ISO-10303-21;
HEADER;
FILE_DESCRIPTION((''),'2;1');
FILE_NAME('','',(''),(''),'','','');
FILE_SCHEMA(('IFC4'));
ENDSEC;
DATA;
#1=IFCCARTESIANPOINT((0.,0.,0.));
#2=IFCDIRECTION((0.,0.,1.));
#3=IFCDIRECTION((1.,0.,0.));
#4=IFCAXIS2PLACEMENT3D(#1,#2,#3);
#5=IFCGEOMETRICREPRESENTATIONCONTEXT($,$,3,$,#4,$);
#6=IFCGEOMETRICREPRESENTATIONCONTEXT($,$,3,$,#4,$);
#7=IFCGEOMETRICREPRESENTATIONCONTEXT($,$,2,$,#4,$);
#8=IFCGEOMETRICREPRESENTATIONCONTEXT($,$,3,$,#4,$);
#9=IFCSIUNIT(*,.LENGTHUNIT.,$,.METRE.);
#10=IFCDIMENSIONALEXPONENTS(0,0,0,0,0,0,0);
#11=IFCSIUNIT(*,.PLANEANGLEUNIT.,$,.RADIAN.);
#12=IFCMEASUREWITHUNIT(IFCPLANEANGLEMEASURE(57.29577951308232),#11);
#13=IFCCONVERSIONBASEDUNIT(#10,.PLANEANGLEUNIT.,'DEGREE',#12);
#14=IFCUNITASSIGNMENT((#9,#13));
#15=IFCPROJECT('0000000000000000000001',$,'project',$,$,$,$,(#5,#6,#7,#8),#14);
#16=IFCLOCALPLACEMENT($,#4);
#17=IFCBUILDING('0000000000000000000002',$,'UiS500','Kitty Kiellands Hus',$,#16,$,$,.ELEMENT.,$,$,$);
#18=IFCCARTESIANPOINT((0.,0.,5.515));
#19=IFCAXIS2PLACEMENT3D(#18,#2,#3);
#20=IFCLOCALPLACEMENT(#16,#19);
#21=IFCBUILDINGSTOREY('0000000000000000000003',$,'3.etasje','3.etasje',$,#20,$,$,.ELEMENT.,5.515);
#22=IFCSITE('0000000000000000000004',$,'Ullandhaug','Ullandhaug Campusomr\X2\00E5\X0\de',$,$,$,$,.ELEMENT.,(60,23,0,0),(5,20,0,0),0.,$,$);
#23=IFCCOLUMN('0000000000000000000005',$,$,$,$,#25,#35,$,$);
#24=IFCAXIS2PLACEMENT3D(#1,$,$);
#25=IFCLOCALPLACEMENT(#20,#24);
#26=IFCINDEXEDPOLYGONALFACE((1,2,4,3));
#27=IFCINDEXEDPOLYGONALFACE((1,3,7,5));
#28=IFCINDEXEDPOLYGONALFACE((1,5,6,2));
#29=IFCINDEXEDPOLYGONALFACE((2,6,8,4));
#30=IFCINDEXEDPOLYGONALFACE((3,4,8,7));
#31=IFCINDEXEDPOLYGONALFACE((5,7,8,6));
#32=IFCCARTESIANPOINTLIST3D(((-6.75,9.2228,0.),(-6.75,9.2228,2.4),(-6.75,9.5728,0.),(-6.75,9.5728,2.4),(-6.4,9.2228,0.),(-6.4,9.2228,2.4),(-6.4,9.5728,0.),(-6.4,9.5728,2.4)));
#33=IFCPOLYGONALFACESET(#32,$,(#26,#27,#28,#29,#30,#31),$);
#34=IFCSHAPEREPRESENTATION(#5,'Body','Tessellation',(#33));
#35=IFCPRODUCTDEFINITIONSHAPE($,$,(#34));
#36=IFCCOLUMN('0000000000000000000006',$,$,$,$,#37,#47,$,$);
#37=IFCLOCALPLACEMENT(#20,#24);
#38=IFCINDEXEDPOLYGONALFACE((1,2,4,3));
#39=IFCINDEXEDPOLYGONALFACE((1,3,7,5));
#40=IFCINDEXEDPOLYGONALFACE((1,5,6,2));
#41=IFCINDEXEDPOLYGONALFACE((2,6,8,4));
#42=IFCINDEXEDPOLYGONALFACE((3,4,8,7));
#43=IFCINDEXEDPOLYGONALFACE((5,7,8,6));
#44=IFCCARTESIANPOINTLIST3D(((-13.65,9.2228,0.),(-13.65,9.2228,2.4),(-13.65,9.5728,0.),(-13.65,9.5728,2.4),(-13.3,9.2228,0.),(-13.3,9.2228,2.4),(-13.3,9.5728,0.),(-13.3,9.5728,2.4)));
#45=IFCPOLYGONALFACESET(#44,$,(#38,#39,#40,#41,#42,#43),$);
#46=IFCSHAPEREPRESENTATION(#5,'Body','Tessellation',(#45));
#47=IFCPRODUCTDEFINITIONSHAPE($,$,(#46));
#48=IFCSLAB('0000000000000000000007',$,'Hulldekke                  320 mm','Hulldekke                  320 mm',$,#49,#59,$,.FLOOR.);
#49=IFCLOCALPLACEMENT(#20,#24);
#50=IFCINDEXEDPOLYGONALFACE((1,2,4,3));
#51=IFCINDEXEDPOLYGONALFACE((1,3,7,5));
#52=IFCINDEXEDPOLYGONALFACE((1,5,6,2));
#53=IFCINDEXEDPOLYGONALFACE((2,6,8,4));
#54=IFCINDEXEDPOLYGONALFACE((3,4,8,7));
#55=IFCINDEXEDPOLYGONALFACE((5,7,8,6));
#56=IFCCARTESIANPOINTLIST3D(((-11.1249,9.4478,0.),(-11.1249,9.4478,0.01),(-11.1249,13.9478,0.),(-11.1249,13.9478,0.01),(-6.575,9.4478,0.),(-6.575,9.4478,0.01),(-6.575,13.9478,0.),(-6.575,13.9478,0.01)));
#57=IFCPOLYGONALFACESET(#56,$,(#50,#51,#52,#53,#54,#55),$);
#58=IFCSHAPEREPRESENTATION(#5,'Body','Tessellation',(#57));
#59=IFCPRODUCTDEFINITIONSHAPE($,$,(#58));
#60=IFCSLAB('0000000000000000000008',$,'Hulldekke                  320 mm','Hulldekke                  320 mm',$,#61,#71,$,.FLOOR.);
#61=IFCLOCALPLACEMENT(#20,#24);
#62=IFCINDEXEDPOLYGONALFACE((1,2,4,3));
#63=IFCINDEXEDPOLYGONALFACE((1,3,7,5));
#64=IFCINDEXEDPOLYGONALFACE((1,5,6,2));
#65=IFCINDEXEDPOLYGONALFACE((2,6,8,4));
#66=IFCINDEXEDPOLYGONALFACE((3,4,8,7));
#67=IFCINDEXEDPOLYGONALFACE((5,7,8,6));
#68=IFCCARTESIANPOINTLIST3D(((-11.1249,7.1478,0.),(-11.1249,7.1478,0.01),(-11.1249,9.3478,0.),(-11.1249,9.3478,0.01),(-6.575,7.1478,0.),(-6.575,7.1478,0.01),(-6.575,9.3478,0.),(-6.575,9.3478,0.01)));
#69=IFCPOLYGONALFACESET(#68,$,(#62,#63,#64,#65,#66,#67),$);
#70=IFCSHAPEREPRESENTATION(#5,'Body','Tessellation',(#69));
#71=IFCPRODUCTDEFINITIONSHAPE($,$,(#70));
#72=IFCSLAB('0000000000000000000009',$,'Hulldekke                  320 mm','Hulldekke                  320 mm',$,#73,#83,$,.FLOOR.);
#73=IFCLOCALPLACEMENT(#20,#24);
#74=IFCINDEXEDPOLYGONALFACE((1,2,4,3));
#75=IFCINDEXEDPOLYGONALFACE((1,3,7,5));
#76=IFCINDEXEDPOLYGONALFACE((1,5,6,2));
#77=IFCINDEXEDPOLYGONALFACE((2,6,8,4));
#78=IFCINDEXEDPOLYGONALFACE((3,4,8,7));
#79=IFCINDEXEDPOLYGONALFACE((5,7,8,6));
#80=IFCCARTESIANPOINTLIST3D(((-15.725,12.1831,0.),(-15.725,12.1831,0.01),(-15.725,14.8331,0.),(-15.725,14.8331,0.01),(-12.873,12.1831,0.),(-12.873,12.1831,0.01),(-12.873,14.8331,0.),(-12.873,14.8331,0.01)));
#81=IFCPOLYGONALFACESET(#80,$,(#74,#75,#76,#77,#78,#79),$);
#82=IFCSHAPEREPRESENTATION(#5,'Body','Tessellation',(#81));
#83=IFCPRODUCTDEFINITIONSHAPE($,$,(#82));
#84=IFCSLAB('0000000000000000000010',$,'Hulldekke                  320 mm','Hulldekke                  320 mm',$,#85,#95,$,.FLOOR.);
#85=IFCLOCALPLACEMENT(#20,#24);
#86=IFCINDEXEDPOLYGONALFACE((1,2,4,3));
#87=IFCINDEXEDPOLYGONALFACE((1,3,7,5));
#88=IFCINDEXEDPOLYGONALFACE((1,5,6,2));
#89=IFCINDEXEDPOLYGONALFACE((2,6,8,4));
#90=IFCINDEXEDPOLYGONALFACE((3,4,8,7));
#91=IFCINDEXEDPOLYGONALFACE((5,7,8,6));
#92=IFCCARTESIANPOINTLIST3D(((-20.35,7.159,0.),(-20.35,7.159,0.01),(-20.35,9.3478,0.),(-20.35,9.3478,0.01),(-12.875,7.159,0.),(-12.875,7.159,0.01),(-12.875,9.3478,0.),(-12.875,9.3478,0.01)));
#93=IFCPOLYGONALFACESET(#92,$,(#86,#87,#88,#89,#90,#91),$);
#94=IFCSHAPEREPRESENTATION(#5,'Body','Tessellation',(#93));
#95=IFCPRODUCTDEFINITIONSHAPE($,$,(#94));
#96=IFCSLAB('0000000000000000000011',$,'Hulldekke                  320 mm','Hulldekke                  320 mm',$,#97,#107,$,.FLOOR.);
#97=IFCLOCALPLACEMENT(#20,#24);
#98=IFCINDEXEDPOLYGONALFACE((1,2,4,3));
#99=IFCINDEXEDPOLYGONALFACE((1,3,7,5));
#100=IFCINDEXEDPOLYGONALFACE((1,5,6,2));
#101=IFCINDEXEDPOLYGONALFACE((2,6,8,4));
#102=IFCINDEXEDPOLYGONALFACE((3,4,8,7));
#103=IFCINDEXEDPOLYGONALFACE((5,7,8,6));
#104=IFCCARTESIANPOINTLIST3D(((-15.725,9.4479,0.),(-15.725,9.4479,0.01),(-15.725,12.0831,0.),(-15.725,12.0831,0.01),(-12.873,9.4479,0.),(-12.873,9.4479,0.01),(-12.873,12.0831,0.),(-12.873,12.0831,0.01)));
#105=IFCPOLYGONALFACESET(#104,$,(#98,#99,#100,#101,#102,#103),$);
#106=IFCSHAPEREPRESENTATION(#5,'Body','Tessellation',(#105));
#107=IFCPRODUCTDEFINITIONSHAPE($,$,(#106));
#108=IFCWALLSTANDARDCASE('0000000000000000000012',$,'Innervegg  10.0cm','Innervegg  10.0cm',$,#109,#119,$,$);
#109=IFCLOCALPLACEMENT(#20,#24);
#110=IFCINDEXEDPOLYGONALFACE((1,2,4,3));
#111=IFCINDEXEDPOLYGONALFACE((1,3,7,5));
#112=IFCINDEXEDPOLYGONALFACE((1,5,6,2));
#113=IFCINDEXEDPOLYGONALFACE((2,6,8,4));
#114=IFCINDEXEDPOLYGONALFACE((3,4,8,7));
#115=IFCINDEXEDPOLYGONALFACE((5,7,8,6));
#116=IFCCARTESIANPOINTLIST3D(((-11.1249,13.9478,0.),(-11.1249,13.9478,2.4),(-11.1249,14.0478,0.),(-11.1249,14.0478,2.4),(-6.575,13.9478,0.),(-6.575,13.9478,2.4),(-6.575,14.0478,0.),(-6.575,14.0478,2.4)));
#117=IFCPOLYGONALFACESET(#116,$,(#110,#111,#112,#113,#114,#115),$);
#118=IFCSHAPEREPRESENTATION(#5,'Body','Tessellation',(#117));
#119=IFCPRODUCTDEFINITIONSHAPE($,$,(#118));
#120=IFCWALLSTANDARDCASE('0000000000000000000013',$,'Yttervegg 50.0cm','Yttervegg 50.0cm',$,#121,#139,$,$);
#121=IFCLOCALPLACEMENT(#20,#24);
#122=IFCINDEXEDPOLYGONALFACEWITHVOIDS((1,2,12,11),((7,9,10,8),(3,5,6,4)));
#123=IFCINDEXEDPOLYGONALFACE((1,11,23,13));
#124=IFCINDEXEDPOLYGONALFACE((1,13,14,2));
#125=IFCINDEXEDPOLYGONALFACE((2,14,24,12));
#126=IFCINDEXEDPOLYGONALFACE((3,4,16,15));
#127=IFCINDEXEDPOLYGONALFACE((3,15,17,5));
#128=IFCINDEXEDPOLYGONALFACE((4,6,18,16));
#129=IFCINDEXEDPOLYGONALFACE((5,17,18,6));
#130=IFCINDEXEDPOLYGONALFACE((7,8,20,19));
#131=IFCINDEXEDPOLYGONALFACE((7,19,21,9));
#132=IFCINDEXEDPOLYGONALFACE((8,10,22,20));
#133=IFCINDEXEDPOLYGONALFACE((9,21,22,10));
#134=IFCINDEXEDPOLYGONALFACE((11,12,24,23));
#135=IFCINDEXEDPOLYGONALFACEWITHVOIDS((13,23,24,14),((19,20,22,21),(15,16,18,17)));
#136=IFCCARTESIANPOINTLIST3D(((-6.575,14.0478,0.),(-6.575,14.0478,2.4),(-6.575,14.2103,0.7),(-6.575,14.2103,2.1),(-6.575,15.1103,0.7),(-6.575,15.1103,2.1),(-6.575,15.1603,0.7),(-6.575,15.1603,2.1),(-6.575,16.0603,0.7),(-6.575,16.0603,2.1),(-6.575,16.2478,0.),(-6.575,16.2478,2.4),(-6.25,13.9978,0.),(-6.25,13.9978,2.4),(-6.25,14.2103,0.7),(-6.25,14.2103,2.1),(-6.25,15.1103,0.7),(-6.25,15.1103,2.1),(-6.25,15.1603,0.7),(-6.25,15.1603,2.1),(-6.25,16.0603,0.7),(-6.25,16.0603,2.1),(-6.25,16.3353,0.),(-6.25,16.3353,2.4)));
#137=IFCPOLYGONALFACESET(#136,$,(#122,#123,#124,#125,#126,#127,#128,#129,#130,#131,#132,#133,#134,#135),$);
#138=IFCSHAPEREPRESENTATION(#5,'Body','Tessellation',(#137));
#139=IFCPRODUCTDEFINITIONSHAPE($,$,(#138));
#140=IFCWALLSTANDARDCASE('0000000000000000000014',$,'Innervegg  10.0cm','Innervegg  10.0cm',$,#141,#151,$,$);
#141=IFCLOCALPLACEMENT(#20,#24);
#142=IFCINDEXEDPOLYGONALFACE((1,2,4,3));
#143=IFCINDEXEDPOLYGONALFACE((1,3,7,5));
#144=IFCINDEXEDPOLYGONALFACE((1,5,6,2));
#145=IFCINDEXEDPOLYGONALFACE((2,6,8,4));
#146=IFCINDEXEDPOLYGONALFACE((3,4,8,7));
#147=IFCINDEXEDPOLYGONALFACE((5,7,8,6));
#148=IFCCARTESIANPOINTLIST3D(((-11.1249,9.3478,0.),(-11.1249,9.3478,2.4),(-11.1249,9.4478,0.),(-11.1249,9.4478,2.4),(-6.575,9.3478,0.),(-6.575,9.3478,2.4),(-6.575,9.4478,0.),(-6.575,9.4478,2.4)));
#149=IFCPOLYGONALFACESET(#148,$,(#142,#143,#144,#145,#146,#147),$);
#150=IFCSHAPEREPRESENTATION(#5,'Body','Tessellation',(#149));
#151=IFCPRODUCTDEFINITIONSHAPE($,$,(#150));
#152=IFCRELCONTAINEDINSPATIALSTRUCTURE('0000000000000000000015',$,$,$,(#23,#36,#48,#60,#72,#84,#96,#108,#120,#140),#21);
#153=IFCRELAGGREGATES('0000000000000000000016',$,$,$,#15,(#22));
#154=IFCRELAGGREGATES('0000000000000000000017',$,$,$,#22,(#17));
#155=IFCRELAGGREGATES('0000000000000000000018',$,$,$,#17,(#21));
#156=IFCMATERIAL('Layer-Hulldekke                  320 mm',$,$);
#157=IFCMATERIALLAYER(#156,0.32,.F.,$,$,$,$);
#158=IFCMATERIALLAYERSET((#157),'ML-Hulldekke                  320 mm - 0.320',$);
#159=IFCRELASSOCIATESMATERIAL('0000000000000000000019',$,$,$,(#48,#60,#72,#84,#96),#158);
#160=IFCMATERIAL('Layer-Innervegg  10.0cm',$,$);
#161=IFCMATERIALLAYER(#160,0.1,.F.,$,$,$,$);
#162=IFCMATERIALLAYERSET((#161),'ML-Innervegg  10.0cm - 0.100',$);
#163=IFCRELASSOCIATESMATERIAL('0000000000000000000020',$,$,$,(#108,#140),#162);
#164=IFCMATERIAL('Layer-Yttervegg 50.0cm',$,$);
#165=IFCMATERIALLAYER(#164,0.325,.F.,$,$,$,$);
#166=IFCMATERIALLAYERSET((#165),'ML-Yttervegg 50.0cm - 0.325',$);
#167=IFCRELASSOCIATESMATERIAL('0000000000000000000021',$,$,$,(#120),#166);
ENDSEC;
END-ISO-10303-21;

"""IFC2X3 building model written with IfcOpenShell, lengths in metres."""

from ifc_helpers import new_model, entity, si_unit, converted_unit, frame, origin_with_axes, origin_2d_with_axis, place, context, project, spatial, polyline, rectangle, outline, extrude, material, layer, layer_set, layer_usage, element, save


model = new_model("IFC2X3")

# Units and contexts
context_of_model_1 = context(None, 3, world=origin_with_axes())
context_of_model_2 = context(None, 3, world=origin_with_axes())
context_of_model_3 = context(None, 2, world=origin_with_axes())
context_of_model_4 = context(None, 3, world=origin_with_axes())
ifc_project = project(units=[si_unit("LENGTHUNIT", "METRE"), converted_unit("PLANEANGLEUNIT", "DEGREE", entity("IfcPlaneAngleMeasure", 57.29577951308232), si_unit("PLANEANGLEUNIT", "RADIAN"), dimensions=[0, 0, 0, 0, 0, 0, 0])], contexts=[context_of_model_1, context_of_model_2, context_of_model_3, context_of_model_4])

# Site, building, storey
site = spatial("IfcSite", under=ifc_project, Name="Ullandhaug", Description="Ullandhaug Campusområde", CompositionType="ELEMENT", RefLatitude=(60, 23, 0, 0), RefLongitude=(5, 20, 0, 0), RefElevation=0.0)
building_placement = place(None, origin_with_axes())
building = spatial("IfcBuilding", under=site, at=building_placement, Name="UiS500", Description="Kitty Kiellands Hus", CompositionType="ELEMENT")
storey_placement = place(building_placement, frame((0.0, 0.0, 5.515), z_axis=(0.0, 0.0, 1.0), x_axis=(1.0, 0.0, 0.0)))
storey = spatial("IfcBuildingStorey", under=building, at=storey_placement, Name="3.etasje", Description="3.etasje", CompositionType="ELEMENT", Elevation=5.515)

# Columns
for number, where, z_axis, x_axis in (
    (1, (-6.575, 9.3978, 0.0), (0.0, 0.0, 1.0), (1.0, 0.0, 0.0)),
    (2, (-13.475, 9.3978, 0.0), (0.0, 0.0, 1.0), (1.0, 0.0, 0.0)),
):
    element("IfcColumn", number, at=place(storey_placement, frame(where, z_axis=z_axis, x_axis=x_axis)), inside=storey, context=context_of_model_1, shape_type="SweptSolid", body=[
        extrude(rectangle(XDim=0.35, YDim=0.35, at=origin_2d_with_axis()), origin_with_axes(), (0.0, 0.0, 1.0), 2.4),
    ])

# Slabs
ifc_material_1 = material(Name="Layer-Hulldekke                  320 mm")
ifc_layer_1 = layer(ifc_material_1, 0.32, ventilated=False)
ifc_layer_set_1 = layer_set([ifc_layer_1], Name="ML-Hulldekke                  320 mm - 0.320")
ifc_layer_usage_1 = layer_usage(ifc_layer_set_1, "AXIS2", "POSITIVE", 0.0)
slab_1_placement = place(storey_placement, frame((-11.1249, 9.4478, 0.0), z_axis=(0.0, 0.0, 1.0), x_axis=(1.0, 0.0, 0.0)))
element("IfcSlab", 3, at=slab_1_placement, inside=storey, material=ifc_layer_usage_1, Name="Hulldekke                  320 mm", Description="Hulldekke                  320 mm", PredefinedType="FLOOR", context=context_of_model_1, shape_type="SweptSolid", body=[
    extrude(outline(polyline([(0.0, 0.0), (4.5499, 0.0), (4.5499, 4.5), (0.0, 4.5), (0.0, 0.0)])), origin_with_axes(), (0.0, 0.0, 1.0), 0.01),
])
slab_2_placement = place(storey_placement, frame((-11.1249, 9.3478, 0.0), z_axis=(0.0, 0.0, 1.0), x_axis=(1.0, 0.0, 0.0)))
element("IfcSlab", 4, at=slab_2_placement, inside=storey, material=ifc_layer_usage_1, Name="Hulldekke                  320 mm", Description="Hulldekke                  320 mm", PredefinedType="FLOOR", context=context_of_model_1, shape_type="SweptSolid", body=[
    extrude(outline(polyline([(0.0, 0.0), (2.2, 0.0), (2.2, 4.5499), (0.0, 4.5499), (0.0, 0.0)])), frame((0.0, 0.0, 0.0), z_axis=(0.0, 0.0, 1.0), x_axis=(0.0, -1.0, 0.0)), (0.0, 0.0, 1.0), 0.01),
])
slab_3_placement = place(storey_placement, frame((-12.873, 14.8331, 0.0), z_axis=(0.0, 0.0, 1.0), x_axis=(1.0, 0.0, 0.0)))
element("IfcSlab", 5, at=slab_3_placement, inside=storey, material=ifc_layer_usage_1, Name="Hulldekke                  320 mm", Description="Hulldekke                  320 mm", PredefinedType="FLOOR", context=context_of_model_1, shape_type="SweptSolid", body=[
    extrude(outline(polyline([(0.0, 0.0), (2.852, 0.0), (2.852, 2.65), (0.0, 2.65), (0.0, 0.0)])), frame((0.0, 0.0, 0.0), z_axis=(0.0, 0.0, 1.0), x_axis=(-1.0, 0.0, 0.0)), (0.0, 0.0, 1.0), 0.01),
])
slab_4_placement = place(storey_placement, frame((-20.35, 7.159, 0.0), z_axis=(0.0, 0.0, 1.0), x_axis=(1.0, 0.0, 0.0)))
element("IfcSlab", 6, at=slab_4_placement, inside=storey, material=ifc_layer_usage_1, Name="Hulldekke                  320 mm", Description="Hulldekke                  320 mm", PredefinedType="FLOOR", context=context_of_model_1, shape_type="SweptSolid", body=[
    extrude(outline(polyline([(0.0, 0.0), (7.475, 0.0), (7.475, 2.1888), (0.0, 2.1888), (0.0, 0.0)])), origin_with_axes(), (0.0, 0.0, 1.0), 0.01),
])
slab_5_placement = place(storey_placement, frame((-15.725, 9.4479, 0.0), z_axis=(0.0, 0.0, 1.0), x_axis=(1.0, 0.0, 0.0)))
element("IfcSlab", 7, at=slab_5_placement, inside=storey, material=ifc_layer_usage_1, Name="Hulldekke                  320 mm", Description="Hulldekke                  320 mm", PredefinedType="FLOOR", context=context_of_model_1, shape_type="SweptSolid", body=[
    extrude(outline(polyline([(0.0, 0.0), (2.852, 0.0), (2.852, 2.6351), (0.0, 2.6351), (0.0, 0.0)])), origin_with_axes(), (0.0, 0.0, 1.0), 0.01),
])

# Wall
ifc_material_2 = material(Name="Layer-Innervegg  10.0cm")
ifc_layer_2 = layer(ifc_material_2, 0.1, ventilated=False)
ifc_layer_set_2 = layer_set([ifc_layer_2], Name="ML-Innervegg  10.0cm - 0.100")
ifc_layer_usage_2 = layer_usage(ifc_layer_set_2, "AXIS2", "POSITIVE", 0.0)
wall_1_placement = place(storey_placement, frame((-11.1249, 13.9478, 0.0), z_axis=(0.0, 0.0, 1.0), x_axis=(1.0, 0.0, 0.0)))
element("IfcWallStandardCase", 8, at=wall_1_placement, inside=storey, material=ifc_layer_usage_2, Name="Innervegg  10.0cm", Description="Innervegg  10.0cm", context=context_of_model_1, shape_type="SweptSolid", body=[
    extrude(outline(polyline([(0.0, 0.0), (4.5499, 0.0), (4.5499, 0.1), (0.0001, 0.1), (0.0, 0.0)])), origin_with_axes(), (0.0, 0.0, 1.0), 2.4),
])

# Wall, openings
ifc_material_3 = material(Name="Layer-Yttervegg 50.0cm")
ifc_layer_3 = layer(ifc_material_3, 0.325, ventilated=False)
ifc_layer_set_3 = layer_set([ifc_layer_3], Name="ML-Yttervegg 50.0cm - 0.325")
ifc_layer_usage_3 = layer_usage(ifc_layer_set_3, "AXIS2", "POSITIVE", 0.0)
wall_2_placement = place(storey_placement, frame((-6.25, 13.9978, 0.0), z_axis=(0.0, 0.0, 1.0), x_axis=(0.0, 1.0, 0.0)))
wall_2 = element("IfcWallStandardCase", 9, at=wall_2_placement, inside=storey, material=ifc_layer_usage_3, Name="Yttervegg 50.0cm", Description="Yttervegg 50.0cm", context=context_of_model_1, shape_type="SweptSolid", body=[
    extrude(outline(polyline([(0.0, 0.0), (2.3375, 0.0), (2.25, 0.325), (0.05, 0.325), (0.0, 0.0)])), frame((0.0, 0.0, 0.0), z_axis=(0.0, 0.0, 1.0), x_axis=(1.0, 0.0, 0.0)), (0.0, 0.0, 1.0), 2.4),
])
opening_1_placement = place(wall_2_placement, frame((0.2125, 0.325, 0.7), z_axis=(0.0, 0.0, 1.0), x_axis=(1.0, 0.0, 0.0)))
element("IfcOpeningElement", 10, at=opening_1_placement, cuts=wall_2, context=context_of_model_1, shape_type="SweptSolid", body=[
    extrude(outline(polyline([(0.0, 0.0), (1.4, 0.0), (1.4, 0.9), (0.0, 0.9), (0.0, 0.0)])), frame((0.0, 0.0, 0.0), z_axis=(0.0, 1.0, 0.0), x_axis=(0.0, 0.0, 1.0)), (0.0, 0.0, -1.0), 0.325),
])
opening_2_placement = place(wall_2_placement, frame((1.1625, 0.325, 0.7), z_axis=(0.0, 0.0, 1.0), x_axis=(1.0, 0.0, 0.0)))
element("IfcOpeningElement", 11, at=opening_2_placement, cuts=wall_2, context=context_of_model_1, shape_type="SweptSolid", body=[
    extrude(outline(polyline([(0.0, 0.0), (1.4, 0.0), (1.4, 0.9), (0.0, 0.9), (0.0, 0.0)])), frame((0.0, 0.0, 0.0), z_axis=(0.0, 1.0, 0.0), x_axis=(0.0, 0.0, 1.0)), (0.0, 0.0, -1.0), 0.325),
])

# Wall
wall_3_placement = place(storey_placement, frame((-11.1249, 9.3478, 0.0), z_axis=(0.0, 0.0, 1.0), x_axis=(1.0, 0.0, 0.0)))
element("IfcWallStandardCase", 12, at=wall_3_placement, inside=storey, material=ifc_layer_usage_2, Name="Innervegg  10.0cm", Description="Innervegg  10.0cm", context=context_of_model_1, shape_type="SweptSolid", body=[
    extrude(outline(polyline([(0.0, 0.0), (4.5499, 0.0), (4.5499, 0.1), (0.0, 0.1), (0.0, 0.0)])), origin_with_axes(), (0.0, 0.0, 1.0), 2.4),
])

save(model, "model.ifc")
